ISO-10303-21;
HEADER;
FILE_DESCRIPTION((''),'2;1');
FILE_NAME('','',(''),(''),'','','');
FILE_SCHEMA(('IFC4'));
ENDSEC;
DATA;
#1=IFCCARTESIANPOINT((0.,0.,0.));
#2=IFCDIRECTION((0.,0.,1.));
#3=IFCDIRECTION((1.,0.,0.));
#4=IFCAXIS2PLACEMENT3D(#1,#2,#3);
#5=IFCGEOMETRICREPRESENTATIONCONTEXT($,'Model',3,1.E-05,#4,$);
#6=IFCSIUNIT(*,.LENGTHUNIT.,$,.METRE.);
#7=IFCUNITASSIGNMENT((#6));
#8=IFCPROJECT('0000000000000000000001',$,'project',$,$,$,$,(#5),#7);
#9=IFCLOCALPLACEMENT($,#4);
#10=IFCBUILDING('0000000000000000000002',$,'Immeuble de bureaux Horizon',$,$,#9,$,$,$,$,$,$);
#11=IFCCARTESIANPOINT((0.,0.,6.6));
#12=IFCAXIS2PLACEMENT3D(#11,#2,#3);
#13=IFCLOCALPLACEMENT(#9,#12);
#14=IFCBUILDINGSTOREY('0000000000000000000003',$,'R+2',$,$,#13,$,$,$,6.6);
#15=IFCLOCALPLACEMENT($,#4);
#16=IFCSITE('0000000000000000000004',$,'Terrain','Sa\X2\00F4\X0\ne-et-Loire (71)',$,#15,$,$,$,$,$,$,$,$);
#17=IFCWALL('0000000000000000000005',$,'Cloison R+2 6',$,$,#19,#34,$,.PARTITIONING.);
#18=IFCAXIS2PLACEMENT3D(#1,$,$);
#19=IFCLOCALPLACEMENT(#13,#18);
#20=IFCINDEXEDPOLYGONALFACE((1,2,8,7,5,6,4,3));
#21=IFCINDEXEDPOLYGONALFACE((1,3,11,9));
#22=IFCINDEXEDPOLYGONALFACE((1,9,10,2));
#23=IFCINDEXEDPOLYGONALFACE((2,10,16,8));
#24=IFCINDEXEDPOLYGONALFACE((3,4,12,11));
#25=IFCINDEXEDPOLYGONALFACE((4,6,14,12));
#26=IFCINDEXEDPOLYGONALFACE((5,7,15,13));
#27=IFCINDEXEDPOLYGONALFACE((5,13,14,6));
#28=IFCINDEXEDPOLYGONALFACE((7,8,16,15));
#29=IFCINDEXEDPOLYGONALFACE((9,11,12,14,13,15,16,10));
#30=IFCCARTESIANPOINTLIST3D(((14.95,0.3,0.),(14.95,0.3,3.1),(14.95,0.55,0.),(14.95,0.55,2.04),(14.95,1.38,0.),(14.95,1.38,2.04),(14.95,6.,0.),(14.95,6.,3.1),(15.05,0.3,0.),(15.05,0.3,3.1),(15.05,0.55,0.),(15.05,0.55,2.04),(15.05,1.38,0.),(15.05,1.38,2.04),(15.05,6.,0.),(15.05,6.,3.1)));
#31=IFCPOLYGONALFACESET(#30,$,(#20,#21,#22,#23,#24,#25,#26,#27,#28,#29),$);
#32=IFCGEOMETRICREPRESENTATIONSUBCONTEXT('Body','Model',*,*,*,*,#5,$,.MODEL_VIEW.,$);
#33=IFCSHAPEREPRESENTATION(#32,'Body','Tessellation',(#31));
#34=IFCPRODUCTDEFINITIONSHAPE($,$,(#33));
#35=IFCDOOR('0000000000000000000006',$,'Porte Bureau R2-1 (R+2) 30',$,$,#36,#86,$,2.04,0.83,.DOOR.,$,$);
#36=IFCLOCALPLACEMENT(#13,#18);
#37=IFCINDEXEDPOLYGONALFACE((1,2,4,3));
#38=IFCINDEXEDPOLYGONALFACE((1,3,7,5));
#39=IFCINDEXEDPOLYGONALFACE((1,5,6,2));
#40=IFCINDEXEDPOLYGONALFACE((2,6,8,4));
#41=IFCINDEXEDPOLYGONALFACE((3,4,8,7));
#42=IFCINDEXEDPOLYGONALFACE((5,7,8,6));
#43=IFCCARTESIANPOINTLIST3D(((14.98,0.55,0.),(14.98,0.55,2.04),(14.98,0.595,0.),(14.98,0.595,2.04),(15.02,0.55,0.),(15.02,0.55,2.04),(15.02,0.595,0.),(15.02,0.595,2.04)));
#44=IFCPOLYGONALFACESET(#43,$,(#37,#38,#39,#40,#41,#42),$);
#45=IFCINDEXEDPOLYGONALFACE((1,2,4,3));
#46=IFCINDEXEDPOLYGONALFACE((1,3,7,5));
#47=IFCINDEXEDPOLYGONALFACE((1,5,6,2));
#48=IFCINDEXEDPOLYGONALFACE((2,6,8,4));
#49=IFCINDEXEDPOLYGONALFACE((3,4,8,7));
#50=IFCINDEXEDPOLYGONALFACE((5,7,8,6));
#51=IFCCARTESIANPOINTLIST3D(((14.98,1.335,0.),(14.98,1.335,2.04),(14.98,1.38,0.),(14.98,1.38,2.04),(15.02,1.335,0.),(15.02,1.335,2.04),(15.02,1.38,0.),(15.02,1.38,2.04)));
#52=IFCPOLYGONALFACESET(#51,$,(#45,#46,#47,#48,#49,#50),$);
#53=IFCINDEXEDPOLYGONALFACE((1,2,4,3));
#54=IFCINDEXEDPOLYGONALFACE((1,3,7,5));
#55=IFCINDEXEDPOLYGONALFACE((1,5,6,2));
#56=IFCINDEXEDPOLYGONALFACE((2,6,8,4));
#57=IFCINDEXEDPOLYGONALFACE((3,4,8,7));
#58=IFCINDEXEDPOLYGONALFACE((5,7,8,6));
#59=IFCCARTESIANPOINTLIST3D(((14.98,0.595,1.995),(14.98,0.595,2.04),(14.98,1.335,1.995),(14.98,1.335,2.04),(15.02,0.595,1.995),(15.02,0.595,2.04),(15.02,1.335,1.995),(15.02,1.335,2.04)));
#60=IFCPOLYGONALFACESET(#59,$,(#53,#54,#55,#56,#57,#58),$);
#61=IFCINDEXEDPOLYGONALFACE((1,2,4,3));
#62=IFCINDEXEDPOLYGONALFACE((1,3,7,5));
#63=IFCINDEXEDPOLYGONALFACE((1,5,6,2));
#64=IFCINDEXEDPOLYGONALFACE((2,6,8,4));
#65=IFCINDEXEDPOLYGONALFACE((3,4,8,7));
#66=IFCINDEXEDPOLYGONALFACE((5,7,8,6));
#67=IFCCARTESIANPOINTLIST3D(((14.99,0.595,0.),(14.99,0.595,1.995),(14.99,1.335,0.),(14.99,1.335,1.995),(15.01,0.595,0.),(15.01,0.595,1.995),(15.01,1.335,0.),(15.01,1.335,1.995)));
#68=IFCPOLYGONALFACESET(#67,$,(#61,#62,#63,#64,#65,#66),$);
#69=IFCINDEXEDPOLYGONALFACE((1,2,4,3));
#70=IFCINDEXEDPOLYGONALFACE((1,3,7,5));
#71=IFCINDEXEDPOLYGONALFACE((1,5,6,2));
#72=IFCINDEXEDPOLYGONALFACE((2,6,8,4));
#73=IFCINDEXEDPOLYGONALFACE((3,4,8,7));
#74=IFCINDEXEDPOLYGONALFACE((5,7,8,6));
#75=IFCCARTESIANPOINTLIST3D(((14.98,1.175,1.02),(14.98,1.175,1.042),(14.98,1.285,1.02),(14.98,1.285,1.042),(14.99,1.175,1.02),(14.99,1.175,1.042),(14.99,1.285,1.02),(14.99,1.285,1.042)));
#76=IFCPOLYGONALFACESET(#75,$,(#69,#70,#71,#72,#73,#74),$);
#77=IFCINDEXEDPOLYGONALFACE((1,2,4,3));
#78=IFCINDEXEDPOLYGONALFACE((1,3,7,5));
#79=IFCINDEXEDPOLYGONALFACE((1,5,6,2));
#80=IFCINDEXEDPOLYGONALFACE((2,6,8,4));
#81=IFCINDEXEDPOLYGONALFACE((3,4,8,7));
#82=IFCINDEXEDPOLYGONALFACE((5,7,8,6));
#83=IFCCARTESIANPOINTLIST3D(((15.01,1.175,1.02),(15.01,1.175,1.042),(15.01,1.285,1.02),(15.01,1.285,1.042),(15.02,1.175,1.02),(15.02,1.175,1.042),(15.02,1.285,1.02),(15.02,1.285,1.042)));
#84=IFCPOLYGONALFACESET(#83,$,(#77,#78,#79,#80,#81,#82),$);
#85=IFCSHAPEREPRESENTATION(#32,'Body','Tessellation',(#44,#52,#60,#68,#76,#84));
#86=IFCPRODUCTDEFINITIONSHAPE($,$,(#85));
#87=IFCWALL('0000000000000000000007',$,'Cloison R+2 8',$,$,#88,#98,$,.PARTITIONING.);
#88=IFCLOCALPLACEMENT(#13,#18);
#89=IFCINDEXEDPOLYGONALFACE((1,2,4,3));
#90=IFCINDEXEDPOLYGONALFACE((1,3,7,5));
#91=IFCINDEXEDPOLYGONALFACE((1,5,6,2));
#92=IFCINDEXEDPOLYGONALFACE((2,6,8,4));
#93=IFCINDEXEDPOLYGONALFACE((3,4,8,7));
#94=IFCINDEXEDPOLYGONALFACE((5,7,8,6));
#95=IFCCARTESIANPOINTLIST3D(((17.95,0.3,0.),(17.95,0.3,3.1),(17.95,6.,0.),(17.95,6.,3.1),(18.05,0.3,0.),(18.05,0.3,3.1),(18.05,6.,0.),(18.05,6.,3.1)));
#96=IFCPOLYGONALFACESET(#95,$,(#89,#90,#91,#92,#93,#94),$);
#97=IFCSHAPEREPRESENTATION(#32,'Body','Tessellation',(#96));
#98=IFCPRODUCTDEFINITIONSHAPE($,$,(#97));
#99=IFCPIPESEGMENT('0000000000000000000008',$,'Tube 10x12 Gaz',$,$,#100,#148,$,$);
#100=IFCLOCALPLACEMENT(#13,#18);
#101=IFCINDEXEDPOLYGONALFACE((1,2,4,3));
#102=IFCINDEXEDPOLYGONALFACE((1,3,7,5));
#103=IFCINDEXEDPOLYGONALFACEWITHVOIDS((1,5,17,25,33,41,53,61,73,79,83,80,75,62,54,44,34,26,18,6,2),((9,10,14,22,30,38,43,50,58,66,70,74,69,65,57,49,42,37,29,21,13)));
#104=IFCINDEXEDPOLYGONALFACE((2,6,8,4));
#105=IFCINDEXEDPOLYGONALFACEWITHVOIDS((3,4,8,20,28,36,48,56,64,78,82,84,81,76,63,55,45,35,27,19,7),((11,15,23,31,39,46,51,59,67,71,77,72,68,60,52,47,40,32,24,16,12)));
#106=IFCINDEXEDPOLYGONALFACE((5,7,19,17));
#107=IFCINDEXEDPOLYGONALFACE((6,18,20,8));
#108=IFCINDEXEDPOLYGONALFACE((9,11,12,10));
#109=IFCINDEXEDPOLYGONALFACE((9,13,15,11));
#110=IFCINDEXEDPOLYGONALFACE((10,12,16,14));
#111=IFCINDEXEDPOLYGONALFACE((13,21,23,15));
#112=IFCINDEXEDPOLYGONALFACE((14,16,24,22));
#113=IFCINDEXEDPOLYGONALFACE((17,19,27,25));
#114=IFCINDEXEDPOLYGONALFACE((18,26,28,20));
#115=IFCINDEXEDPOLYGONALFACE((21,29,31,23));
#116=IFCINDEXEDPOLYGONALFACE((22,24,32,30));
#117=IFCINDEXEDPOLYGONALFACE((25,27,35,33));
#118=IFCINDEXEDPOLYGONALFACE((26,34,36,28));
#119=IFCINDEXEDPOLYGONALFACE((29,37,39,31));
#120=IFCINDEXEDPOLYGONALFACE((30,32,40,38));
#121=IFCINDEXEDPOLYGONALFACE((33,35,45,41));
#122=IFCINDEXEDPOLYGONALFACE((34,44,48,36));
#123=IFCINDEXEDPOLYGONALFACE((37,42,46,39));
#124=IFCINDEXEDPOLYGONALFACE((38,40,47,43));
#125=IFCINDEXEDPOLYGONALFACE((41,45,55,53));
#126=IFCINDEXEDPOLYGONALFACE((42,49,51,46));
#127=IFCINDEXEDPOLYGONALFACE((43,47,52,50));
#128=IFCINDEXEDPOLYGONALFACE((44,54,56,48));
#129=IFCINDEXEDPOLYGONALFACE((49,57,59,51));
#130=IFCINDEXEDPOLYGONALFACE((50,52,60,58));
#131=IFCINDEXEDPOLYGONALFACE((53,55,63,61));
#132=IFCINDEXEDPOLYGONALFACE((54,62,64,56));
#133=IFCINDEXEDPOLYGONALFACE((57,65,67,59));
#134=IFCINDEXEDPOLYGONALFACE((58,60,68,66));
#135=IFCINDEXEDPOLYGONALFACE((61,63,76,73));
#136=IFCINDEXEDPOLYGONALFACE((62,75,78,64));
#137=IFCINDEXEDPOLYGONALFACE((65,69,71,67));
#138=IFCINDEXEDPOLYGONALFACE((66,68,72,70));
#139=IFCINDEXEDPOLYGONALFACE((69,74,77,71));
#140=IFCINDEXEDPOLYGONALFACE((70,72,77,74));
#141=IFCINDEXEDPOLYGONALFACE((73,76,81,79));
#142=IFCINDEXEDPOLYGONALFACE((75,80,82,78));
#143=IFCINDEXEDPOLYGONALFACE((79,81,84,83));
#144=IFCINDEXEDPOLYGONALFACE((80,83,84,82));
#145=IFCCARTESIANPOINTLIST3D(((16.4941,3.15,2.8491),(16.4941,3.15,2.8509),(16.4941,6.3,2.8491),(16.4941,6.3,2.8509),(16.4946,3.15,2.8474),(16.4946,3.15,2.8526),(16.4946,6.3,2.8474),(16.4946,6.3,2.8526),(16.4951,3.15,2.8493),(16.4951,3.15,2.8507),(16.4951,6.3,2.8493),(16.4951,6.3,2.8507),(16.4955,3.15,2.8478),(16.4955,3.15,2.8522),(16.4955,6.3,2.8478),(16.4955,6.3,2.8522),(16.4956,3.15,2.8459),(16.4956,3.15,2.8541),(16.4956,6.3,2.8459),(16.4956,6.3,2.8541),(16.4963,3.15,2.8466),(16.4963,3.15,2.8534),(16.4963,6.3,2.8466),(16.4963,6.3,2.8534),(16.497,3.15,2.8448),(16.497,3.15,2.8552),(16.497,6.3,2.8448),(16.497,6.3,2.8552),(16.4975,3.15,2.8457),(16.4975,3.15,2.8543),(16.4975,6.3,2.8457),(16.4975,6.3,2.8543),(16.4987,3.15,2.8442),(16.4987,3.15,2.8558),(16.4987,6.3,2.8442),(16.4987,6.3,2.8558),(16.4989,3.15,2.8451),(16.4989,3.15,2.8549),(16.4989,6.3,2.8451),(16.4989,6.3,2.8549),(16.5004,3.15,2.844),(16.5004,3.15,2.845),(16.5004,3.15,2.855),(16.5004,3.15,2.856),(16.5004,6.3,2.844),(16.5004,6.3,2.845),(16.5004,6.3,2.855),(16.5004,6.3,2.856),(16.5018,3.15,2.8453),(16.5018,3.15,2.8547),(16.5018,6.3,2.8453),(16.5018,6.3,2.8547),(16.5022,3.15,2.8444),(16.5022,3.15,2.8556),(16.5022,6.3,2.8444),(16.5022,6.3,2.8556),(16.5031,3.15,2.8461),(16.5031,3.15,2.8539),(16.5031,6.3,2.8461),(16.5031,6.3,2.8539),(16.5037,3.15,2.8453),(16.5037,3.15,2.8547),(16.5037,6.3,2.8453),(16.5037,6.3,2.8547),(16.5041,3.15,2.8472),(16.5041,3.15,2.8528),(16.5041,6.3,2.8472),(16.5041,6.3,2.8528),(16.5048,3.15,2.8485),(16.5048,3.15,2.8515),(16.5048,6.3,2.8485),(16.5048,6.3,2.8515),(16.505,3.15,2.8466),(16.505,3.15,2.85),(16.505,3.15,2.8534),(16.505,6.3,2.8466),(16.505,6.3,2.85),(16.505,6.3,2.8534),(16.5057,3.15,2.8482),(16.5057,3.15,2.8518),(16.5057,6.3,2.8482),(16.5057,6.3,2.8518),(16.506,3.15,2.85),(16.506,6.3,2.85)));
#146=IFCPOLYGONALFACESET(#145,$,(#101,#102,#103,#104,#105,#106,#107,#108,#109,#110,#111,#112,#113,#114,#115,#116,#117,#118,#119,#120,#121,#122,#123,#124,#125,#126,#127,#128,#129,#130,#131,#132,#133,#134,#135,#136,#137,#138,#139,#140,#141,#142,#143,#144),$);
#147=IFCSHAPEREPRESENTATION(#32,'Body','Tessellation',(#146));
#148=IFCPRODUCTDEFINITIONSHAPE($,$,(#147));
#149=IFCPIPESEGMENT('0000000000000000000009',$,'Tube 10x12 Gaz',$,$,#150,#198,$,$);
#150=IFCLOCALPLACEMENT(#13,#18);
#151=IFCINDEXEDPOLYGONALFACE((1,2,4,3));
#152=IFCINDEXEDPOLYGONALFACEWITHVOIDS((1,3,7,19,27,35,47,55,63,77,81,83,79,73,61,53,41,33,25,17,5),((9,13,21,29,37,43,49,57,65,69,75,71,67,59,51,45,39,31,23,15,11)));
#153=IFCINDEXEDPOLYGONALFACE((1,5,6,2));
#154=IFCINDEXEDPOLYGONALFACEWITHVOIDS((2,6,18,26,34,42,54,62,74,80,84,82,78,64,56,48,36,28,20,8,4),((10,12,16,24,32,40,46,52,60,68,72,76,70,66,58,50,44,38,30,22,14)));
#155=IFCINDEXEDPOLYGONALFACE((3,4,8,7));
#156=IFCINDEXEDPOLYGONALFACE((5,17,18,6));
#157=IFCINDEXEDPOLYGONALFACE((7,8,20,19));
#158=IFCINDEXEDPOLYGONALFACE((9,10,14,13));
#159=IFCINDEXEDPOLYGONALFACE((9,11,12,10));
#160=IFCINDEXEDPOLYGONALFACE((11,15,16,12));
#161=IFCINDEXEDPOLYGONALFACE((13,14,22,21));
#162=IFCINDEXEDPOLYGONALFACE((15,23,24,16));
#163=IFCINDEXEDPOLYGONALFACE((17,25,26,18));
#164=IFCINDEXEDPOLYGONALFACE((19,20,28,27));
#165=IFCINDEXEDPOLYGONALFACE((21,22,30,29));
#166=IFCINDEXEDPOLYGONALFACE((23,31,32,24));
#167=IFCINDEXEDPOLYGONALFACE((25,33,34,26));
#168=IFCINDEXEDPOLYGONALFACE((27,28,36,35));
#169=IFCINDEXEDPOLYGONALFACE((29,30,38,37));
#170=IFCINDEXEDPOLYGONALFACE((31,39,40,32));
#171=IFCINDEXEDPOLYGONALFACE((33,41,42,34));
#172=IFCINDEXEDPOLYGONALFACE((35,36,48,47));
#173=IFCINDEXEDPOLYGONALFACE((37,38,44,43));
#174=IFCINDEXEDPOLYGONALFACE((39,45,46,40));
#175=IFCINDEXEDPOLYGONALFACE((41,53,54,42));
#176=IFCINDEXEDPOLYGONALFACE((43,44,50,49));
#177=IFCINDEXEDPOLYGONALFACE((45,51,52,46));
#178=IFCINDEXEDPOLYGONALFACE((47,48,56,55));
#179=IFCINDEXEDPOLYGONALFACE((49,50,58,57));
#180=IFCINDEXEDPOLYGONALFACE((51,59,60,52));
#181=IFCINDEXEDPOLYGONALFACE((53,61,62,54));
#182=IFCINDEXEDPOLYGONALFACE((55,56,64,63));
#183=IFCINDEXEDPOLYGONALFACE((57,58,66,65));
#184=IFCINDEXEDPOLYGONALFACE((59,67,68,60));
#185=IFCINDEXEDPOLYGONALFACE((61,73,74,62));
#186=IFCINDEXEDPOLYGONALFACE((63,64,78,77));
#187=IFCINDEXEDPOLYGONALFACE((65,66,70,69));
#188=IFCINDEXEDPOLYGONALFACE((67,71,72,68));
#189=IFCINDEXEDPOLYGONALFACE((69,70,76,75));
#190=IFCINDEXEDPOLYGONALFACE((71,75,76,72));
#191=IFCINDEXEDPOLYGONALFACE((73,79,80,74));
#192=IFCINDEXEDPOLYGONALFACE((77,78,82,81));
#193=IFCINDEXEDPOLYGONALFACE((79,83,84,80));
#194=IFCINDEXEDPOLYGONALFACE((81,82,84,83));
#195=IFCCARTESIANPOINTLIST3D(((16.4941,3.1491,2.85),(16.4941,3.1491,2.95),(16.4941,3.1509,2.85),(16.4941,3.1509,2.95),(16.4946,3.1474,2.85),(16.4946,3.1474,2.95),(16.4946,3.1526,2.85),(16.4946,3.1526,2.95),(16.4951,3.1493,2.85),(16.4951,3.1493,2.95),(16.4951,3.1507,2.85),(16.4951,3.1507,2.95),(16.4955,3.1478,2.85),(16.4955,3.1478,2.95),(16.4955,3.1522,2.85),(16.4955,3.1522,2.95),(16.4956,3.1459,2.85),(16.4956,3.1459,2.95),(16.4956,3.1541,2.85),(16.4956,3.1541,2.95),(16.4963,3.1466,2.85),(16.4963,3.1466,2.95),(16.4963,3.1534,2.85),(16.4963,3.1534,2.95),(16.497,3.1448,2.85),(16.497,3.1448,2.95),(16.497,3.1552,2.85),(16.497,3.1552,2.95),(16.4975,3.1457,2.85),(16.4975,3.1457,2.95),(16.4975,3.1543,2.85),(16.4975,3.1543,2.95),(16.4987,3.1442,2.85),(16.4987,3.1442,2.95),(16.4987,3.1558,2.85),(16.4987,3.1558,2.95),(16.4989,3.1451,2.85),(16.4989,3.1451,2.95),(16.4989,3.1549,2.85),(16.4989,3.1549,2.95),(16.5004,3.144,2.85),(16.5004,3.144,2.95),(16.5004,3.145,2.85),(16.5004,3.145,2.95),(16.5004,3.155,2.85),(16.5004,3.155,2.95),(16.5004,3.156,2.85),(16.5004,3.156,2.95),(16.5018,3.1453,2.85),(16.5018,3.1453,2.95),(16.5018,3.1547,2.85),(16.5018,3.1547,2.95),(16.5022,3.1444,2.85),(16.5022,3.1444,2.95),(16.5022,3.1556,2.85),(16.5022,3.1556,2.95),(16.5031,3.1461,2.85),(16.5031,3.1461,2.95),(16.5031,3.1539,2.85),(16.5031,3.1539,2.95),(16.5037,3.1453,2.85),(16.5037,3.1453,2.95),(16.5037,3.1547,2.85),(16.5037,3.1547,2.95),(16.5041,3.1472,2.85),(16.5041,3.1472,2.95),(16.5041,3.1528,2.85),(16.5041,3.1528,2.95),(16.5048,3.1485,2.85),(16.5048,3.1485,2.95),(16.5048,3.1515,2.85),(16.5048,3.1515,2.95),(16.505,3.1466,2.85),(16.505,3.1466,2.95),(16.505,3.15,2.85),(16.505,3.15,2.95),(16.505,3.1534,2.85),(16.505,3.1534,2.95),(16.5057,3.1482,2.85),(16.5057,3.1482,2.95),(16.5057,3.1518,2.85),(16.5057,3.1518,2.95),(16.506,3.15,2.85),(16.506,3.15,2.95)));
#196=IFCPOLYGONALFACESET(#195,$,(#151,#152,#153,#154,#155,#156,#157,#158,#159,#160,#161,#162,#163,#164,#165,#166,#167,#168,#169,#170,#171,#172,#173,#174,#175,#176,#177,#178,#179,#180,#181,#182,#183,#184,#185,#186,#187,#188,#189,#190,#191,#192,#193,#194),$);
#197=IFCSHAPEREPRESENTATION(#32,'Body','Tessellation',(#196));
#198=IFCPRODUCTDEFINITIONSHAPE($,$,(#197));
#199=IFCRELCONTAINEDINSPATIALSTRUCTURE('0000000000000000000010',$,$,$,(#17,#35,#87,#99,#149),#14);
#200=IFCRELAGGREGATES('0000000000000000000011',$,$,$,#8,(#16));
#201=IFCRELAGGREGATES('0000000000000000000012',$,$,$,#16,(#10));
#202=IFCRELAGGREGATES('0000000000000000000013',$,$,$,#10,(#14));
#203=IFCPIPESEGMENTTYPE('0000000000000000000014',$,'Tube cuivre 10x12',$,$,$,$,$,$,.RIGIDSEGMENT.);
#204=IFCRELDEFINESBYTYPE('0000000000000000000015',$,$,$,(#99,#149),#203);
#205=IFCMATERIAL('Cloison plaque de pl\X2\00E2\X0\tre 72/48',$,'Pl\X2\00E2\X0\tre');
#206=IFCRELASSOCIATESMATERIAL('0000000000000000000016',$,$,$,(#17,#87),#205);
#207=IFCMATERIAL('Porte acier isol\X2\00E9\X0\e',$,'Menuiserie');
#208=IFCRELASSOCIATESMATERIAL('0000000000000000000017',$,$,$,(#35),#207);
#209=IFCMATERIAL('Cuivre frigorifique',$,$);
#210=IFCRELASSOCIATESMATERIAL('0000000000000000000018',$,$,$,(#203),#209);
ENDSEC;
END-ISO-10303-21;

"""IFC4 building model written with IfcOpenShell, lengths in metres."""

from ifc_helpers import new_model, si_unit, frame, frame_2d, origin_with_axes, place, context, subcontext, project, spatial, rectangle, hollow_circle, extrude, material, type_object, element, fill, save


model = new_model("IFC4")

# Units and contexts
model_context = context("Model", 3, precision=1e-05, world=origin_with_axes())
body_context = subcontext(model_context, "Body", "Model", "MODEL_VIEW")
ifc_project = project(units=[si_unit("LENGTHUNIT", "METRE")], contexts=[model_context])

# Site, building, storey
site_placement = place(None, origin_with_axes())
site = spatial("IfcSite", under=ifc_project, at=site_placement, Name="Terrain", Description="Saône-et-Loire (71)")
building_placement = place(None, origin_with_axes())
building = spatial("IfcBuilding", under=site, at=building_placement, Name="Immeuble de bureaux Horizon")
storey_placement = place(building_placement, frame((0.0, 0.0, 6.6), z_axis=(0.0, 0.0, 1.0), x_axis=(1.0, 0.0, 0.0)))
storey = spatial("IfcBuildingStorey", under=building, at=storey_placement, Name="R+2", Elevation=6.6)

# Wall, opening, door
ifc_material_1 = material(Name="Cloison plaque de plâtre 72/48", Category="Plâtre")
wall_1_placement = place(storey_placement, frame((14.95, 0.3, 0.0), z_axis=(0.0, 0.0, 1.0), x_axis=(1.0, 0.0, 0.0)))
wall_1 = element("IfcWall", 1, at=wall_1_placement, inside=storey, material=ifc_material_1, Name="Cloison R+2 6", PredefinedType="PARTITIONING", context=body_context, shape_type="SweptSolid", body=[
    extrude(rectangle(XDim=0.1, YDim=5.7, at=frame_2d((0.05, 2.85))), origin_with_axes(), (0.0, 0.0, 1.0), 3.1),
])
opening_placement = place(storey_placement, frame((14.9, 0.55, 0.0), z_axis=(0.0, 0.0, 1.0), x_axis=(1.0, 0.0, 0.0)))
opening = element("IfcOpeningElement", 2, at=opening_placement, cuts=wall_1, context=body_context, shape_type="SweptSolid", body=[
    extrude(rectangle(XDim=0.2, YDim=0.83, at=frame_2d((0.1, 0.415))), origin_with_axes(), (0.0, 0.0, 1.0), 2.04),
])
ifc_material_2 = material(Name="Porte acier isolée", Category="Menuiserie")
door_placement = place(storey_placement, frame((14.98, 0.55, 0.0), z_axis=(0.0, 0.0, 1.0), x_axis=(1.0, 0.0, 0.0)))
door = element("IfcDoor", 3, at=door_placement, inside=storey, material=ifc_material_2, Name="Porte Bureau R2-1 (R+2) 30", OverallHeight=2.04, OverallWidth=0.83, PredefinedType="DOOR", context=body_context, shape_type="SweptSolid", body=[
    extrude(rectangle(XDim=0.04, YDim=0.045, at=frame_2d((0.02, 0.0225))), origin_with_axes(), (0.0, 0.0, 1.0), 2.04),
    extrude(rectangle(XDim=0.04, YDim=0.045, at=frame_2d((0.02, 0.0225))), frame((0.0, 0.785, 0.0), z_axis=(0.0, 0.0, 1.0), x_axis=(1.0, 0.0, 0.0)), (0.0, 0.0, 1.0), 2.04),
    extrude(rectangle(XDim=0.04, YDim=0.74, at=frame_2d((0.02, 0.37))), frame((0.0, 0.045, 1.995), z_axis=(0.0, 0.0, 1.0), x_axis=(1.0, 0.0, 0.0)), (0.0, 0.0, 1.0), 0.045),
    extrude(rectangle(XDim=0.02, YDim=0.74, at=frame_2d((0.01, 0.37))), frame((0.01, 0.045, 0.0), z_axis=(0.0, 0.0, 1.0), x_axis=(1.0, 0.0, 0.0)), (0.0, 0.0, 1.0), 1.995),
    extrude(rectangle(XDim=0.01, YDim=0.11, at=frame_2d((0.005, 0.055))), frame((0.0, 0.625, 1.02), z_axis=(0.0, 0.0, 1.0), x_axis=(1.0, 0.0, 0.0)), (0.0, 0.0, 1.0), 0.022),
    extrude(rectangle(XDim=0.01, YDim=0.11, at=frame_2d((0.005, 0.055))), frame((0.03, 0.625, 1.02), z_axis=(0.0, 0.0, 1.0), x_axis=(1.0, 0.0, 0.0)), (0.0, 0.0, 1.0), 0.022),
])
fill(opening, door)

# Wall
wall_2_placement = place(storey_placement, frame((17.95, 0.3, 0.0), z_axis=(0.0, 0.0, 1.0), x_axis=(1.0, 0.0, 0.0)))
element("IfcWall", 4, at=wall_2_placement, inside=storey, material=ifc_material_1, Name="Cloison R+2 8", PredefinedType="PARTITIONING", context=body_context, shape_type="SweptSolid", body=[
    extrude(rectangle(XDim=0.1, YDim=5.7, at=frame_2d((0.05, 2.85))), origin_with_axes(), (0.0, 0.0, 1.0), 3.1),
])

# Pipe segments
ifc_material_3 = material(Name="Cuivre frigorifique")
pipe_segment_type_1 = type_object("IfcPipeSegmentType", Name="Tube cuivre 10x12", PredefinedType="RIGIDSEGMENT", material=ifc_material_3)
pipe_segment_1_placement = place(storey_placement, frame((16.5, 6.3, 2.85), z_axis=(0.0, -1.0, 0.0), x_axis=(1.0, 0.0, 0.0)))
element("IfcPipeSegment", 5, at=pipe_segment_1_placement, inside=storey, type_object=pipe_segment_type_1, Name="Tube 10x12 Gaz", context=body_context, shape_type="SweptSolid", body=[
    extrude(hollow_circle(Radius=0.006, WallThickness=0.001), origin_with_axes(), (0.0, 0.0, 1.0), 3.15),
])
pipe_segment_2_placement = place(storey_placement, frame((16.5, 3.15, 2.85), z_axis=(0.0, 0.0, 1.0), x_axis=(1.0, 0.0, 0.0)))
element("IfcPipeSegment", 6, at=pipe_segment_2_placement, inside=storey, type_object=pipe_segment_type_1, Name="Tube 10x12 Gaz", context=body_context, shape_type="SweptSolid", body=[
    extrude(hollow_circle(Radius=0.006, WallThickness=0.001), origin_with_axes(), (0.0, 0.0, 1.0), 0.1),
])

save(model, "model.ifc")
